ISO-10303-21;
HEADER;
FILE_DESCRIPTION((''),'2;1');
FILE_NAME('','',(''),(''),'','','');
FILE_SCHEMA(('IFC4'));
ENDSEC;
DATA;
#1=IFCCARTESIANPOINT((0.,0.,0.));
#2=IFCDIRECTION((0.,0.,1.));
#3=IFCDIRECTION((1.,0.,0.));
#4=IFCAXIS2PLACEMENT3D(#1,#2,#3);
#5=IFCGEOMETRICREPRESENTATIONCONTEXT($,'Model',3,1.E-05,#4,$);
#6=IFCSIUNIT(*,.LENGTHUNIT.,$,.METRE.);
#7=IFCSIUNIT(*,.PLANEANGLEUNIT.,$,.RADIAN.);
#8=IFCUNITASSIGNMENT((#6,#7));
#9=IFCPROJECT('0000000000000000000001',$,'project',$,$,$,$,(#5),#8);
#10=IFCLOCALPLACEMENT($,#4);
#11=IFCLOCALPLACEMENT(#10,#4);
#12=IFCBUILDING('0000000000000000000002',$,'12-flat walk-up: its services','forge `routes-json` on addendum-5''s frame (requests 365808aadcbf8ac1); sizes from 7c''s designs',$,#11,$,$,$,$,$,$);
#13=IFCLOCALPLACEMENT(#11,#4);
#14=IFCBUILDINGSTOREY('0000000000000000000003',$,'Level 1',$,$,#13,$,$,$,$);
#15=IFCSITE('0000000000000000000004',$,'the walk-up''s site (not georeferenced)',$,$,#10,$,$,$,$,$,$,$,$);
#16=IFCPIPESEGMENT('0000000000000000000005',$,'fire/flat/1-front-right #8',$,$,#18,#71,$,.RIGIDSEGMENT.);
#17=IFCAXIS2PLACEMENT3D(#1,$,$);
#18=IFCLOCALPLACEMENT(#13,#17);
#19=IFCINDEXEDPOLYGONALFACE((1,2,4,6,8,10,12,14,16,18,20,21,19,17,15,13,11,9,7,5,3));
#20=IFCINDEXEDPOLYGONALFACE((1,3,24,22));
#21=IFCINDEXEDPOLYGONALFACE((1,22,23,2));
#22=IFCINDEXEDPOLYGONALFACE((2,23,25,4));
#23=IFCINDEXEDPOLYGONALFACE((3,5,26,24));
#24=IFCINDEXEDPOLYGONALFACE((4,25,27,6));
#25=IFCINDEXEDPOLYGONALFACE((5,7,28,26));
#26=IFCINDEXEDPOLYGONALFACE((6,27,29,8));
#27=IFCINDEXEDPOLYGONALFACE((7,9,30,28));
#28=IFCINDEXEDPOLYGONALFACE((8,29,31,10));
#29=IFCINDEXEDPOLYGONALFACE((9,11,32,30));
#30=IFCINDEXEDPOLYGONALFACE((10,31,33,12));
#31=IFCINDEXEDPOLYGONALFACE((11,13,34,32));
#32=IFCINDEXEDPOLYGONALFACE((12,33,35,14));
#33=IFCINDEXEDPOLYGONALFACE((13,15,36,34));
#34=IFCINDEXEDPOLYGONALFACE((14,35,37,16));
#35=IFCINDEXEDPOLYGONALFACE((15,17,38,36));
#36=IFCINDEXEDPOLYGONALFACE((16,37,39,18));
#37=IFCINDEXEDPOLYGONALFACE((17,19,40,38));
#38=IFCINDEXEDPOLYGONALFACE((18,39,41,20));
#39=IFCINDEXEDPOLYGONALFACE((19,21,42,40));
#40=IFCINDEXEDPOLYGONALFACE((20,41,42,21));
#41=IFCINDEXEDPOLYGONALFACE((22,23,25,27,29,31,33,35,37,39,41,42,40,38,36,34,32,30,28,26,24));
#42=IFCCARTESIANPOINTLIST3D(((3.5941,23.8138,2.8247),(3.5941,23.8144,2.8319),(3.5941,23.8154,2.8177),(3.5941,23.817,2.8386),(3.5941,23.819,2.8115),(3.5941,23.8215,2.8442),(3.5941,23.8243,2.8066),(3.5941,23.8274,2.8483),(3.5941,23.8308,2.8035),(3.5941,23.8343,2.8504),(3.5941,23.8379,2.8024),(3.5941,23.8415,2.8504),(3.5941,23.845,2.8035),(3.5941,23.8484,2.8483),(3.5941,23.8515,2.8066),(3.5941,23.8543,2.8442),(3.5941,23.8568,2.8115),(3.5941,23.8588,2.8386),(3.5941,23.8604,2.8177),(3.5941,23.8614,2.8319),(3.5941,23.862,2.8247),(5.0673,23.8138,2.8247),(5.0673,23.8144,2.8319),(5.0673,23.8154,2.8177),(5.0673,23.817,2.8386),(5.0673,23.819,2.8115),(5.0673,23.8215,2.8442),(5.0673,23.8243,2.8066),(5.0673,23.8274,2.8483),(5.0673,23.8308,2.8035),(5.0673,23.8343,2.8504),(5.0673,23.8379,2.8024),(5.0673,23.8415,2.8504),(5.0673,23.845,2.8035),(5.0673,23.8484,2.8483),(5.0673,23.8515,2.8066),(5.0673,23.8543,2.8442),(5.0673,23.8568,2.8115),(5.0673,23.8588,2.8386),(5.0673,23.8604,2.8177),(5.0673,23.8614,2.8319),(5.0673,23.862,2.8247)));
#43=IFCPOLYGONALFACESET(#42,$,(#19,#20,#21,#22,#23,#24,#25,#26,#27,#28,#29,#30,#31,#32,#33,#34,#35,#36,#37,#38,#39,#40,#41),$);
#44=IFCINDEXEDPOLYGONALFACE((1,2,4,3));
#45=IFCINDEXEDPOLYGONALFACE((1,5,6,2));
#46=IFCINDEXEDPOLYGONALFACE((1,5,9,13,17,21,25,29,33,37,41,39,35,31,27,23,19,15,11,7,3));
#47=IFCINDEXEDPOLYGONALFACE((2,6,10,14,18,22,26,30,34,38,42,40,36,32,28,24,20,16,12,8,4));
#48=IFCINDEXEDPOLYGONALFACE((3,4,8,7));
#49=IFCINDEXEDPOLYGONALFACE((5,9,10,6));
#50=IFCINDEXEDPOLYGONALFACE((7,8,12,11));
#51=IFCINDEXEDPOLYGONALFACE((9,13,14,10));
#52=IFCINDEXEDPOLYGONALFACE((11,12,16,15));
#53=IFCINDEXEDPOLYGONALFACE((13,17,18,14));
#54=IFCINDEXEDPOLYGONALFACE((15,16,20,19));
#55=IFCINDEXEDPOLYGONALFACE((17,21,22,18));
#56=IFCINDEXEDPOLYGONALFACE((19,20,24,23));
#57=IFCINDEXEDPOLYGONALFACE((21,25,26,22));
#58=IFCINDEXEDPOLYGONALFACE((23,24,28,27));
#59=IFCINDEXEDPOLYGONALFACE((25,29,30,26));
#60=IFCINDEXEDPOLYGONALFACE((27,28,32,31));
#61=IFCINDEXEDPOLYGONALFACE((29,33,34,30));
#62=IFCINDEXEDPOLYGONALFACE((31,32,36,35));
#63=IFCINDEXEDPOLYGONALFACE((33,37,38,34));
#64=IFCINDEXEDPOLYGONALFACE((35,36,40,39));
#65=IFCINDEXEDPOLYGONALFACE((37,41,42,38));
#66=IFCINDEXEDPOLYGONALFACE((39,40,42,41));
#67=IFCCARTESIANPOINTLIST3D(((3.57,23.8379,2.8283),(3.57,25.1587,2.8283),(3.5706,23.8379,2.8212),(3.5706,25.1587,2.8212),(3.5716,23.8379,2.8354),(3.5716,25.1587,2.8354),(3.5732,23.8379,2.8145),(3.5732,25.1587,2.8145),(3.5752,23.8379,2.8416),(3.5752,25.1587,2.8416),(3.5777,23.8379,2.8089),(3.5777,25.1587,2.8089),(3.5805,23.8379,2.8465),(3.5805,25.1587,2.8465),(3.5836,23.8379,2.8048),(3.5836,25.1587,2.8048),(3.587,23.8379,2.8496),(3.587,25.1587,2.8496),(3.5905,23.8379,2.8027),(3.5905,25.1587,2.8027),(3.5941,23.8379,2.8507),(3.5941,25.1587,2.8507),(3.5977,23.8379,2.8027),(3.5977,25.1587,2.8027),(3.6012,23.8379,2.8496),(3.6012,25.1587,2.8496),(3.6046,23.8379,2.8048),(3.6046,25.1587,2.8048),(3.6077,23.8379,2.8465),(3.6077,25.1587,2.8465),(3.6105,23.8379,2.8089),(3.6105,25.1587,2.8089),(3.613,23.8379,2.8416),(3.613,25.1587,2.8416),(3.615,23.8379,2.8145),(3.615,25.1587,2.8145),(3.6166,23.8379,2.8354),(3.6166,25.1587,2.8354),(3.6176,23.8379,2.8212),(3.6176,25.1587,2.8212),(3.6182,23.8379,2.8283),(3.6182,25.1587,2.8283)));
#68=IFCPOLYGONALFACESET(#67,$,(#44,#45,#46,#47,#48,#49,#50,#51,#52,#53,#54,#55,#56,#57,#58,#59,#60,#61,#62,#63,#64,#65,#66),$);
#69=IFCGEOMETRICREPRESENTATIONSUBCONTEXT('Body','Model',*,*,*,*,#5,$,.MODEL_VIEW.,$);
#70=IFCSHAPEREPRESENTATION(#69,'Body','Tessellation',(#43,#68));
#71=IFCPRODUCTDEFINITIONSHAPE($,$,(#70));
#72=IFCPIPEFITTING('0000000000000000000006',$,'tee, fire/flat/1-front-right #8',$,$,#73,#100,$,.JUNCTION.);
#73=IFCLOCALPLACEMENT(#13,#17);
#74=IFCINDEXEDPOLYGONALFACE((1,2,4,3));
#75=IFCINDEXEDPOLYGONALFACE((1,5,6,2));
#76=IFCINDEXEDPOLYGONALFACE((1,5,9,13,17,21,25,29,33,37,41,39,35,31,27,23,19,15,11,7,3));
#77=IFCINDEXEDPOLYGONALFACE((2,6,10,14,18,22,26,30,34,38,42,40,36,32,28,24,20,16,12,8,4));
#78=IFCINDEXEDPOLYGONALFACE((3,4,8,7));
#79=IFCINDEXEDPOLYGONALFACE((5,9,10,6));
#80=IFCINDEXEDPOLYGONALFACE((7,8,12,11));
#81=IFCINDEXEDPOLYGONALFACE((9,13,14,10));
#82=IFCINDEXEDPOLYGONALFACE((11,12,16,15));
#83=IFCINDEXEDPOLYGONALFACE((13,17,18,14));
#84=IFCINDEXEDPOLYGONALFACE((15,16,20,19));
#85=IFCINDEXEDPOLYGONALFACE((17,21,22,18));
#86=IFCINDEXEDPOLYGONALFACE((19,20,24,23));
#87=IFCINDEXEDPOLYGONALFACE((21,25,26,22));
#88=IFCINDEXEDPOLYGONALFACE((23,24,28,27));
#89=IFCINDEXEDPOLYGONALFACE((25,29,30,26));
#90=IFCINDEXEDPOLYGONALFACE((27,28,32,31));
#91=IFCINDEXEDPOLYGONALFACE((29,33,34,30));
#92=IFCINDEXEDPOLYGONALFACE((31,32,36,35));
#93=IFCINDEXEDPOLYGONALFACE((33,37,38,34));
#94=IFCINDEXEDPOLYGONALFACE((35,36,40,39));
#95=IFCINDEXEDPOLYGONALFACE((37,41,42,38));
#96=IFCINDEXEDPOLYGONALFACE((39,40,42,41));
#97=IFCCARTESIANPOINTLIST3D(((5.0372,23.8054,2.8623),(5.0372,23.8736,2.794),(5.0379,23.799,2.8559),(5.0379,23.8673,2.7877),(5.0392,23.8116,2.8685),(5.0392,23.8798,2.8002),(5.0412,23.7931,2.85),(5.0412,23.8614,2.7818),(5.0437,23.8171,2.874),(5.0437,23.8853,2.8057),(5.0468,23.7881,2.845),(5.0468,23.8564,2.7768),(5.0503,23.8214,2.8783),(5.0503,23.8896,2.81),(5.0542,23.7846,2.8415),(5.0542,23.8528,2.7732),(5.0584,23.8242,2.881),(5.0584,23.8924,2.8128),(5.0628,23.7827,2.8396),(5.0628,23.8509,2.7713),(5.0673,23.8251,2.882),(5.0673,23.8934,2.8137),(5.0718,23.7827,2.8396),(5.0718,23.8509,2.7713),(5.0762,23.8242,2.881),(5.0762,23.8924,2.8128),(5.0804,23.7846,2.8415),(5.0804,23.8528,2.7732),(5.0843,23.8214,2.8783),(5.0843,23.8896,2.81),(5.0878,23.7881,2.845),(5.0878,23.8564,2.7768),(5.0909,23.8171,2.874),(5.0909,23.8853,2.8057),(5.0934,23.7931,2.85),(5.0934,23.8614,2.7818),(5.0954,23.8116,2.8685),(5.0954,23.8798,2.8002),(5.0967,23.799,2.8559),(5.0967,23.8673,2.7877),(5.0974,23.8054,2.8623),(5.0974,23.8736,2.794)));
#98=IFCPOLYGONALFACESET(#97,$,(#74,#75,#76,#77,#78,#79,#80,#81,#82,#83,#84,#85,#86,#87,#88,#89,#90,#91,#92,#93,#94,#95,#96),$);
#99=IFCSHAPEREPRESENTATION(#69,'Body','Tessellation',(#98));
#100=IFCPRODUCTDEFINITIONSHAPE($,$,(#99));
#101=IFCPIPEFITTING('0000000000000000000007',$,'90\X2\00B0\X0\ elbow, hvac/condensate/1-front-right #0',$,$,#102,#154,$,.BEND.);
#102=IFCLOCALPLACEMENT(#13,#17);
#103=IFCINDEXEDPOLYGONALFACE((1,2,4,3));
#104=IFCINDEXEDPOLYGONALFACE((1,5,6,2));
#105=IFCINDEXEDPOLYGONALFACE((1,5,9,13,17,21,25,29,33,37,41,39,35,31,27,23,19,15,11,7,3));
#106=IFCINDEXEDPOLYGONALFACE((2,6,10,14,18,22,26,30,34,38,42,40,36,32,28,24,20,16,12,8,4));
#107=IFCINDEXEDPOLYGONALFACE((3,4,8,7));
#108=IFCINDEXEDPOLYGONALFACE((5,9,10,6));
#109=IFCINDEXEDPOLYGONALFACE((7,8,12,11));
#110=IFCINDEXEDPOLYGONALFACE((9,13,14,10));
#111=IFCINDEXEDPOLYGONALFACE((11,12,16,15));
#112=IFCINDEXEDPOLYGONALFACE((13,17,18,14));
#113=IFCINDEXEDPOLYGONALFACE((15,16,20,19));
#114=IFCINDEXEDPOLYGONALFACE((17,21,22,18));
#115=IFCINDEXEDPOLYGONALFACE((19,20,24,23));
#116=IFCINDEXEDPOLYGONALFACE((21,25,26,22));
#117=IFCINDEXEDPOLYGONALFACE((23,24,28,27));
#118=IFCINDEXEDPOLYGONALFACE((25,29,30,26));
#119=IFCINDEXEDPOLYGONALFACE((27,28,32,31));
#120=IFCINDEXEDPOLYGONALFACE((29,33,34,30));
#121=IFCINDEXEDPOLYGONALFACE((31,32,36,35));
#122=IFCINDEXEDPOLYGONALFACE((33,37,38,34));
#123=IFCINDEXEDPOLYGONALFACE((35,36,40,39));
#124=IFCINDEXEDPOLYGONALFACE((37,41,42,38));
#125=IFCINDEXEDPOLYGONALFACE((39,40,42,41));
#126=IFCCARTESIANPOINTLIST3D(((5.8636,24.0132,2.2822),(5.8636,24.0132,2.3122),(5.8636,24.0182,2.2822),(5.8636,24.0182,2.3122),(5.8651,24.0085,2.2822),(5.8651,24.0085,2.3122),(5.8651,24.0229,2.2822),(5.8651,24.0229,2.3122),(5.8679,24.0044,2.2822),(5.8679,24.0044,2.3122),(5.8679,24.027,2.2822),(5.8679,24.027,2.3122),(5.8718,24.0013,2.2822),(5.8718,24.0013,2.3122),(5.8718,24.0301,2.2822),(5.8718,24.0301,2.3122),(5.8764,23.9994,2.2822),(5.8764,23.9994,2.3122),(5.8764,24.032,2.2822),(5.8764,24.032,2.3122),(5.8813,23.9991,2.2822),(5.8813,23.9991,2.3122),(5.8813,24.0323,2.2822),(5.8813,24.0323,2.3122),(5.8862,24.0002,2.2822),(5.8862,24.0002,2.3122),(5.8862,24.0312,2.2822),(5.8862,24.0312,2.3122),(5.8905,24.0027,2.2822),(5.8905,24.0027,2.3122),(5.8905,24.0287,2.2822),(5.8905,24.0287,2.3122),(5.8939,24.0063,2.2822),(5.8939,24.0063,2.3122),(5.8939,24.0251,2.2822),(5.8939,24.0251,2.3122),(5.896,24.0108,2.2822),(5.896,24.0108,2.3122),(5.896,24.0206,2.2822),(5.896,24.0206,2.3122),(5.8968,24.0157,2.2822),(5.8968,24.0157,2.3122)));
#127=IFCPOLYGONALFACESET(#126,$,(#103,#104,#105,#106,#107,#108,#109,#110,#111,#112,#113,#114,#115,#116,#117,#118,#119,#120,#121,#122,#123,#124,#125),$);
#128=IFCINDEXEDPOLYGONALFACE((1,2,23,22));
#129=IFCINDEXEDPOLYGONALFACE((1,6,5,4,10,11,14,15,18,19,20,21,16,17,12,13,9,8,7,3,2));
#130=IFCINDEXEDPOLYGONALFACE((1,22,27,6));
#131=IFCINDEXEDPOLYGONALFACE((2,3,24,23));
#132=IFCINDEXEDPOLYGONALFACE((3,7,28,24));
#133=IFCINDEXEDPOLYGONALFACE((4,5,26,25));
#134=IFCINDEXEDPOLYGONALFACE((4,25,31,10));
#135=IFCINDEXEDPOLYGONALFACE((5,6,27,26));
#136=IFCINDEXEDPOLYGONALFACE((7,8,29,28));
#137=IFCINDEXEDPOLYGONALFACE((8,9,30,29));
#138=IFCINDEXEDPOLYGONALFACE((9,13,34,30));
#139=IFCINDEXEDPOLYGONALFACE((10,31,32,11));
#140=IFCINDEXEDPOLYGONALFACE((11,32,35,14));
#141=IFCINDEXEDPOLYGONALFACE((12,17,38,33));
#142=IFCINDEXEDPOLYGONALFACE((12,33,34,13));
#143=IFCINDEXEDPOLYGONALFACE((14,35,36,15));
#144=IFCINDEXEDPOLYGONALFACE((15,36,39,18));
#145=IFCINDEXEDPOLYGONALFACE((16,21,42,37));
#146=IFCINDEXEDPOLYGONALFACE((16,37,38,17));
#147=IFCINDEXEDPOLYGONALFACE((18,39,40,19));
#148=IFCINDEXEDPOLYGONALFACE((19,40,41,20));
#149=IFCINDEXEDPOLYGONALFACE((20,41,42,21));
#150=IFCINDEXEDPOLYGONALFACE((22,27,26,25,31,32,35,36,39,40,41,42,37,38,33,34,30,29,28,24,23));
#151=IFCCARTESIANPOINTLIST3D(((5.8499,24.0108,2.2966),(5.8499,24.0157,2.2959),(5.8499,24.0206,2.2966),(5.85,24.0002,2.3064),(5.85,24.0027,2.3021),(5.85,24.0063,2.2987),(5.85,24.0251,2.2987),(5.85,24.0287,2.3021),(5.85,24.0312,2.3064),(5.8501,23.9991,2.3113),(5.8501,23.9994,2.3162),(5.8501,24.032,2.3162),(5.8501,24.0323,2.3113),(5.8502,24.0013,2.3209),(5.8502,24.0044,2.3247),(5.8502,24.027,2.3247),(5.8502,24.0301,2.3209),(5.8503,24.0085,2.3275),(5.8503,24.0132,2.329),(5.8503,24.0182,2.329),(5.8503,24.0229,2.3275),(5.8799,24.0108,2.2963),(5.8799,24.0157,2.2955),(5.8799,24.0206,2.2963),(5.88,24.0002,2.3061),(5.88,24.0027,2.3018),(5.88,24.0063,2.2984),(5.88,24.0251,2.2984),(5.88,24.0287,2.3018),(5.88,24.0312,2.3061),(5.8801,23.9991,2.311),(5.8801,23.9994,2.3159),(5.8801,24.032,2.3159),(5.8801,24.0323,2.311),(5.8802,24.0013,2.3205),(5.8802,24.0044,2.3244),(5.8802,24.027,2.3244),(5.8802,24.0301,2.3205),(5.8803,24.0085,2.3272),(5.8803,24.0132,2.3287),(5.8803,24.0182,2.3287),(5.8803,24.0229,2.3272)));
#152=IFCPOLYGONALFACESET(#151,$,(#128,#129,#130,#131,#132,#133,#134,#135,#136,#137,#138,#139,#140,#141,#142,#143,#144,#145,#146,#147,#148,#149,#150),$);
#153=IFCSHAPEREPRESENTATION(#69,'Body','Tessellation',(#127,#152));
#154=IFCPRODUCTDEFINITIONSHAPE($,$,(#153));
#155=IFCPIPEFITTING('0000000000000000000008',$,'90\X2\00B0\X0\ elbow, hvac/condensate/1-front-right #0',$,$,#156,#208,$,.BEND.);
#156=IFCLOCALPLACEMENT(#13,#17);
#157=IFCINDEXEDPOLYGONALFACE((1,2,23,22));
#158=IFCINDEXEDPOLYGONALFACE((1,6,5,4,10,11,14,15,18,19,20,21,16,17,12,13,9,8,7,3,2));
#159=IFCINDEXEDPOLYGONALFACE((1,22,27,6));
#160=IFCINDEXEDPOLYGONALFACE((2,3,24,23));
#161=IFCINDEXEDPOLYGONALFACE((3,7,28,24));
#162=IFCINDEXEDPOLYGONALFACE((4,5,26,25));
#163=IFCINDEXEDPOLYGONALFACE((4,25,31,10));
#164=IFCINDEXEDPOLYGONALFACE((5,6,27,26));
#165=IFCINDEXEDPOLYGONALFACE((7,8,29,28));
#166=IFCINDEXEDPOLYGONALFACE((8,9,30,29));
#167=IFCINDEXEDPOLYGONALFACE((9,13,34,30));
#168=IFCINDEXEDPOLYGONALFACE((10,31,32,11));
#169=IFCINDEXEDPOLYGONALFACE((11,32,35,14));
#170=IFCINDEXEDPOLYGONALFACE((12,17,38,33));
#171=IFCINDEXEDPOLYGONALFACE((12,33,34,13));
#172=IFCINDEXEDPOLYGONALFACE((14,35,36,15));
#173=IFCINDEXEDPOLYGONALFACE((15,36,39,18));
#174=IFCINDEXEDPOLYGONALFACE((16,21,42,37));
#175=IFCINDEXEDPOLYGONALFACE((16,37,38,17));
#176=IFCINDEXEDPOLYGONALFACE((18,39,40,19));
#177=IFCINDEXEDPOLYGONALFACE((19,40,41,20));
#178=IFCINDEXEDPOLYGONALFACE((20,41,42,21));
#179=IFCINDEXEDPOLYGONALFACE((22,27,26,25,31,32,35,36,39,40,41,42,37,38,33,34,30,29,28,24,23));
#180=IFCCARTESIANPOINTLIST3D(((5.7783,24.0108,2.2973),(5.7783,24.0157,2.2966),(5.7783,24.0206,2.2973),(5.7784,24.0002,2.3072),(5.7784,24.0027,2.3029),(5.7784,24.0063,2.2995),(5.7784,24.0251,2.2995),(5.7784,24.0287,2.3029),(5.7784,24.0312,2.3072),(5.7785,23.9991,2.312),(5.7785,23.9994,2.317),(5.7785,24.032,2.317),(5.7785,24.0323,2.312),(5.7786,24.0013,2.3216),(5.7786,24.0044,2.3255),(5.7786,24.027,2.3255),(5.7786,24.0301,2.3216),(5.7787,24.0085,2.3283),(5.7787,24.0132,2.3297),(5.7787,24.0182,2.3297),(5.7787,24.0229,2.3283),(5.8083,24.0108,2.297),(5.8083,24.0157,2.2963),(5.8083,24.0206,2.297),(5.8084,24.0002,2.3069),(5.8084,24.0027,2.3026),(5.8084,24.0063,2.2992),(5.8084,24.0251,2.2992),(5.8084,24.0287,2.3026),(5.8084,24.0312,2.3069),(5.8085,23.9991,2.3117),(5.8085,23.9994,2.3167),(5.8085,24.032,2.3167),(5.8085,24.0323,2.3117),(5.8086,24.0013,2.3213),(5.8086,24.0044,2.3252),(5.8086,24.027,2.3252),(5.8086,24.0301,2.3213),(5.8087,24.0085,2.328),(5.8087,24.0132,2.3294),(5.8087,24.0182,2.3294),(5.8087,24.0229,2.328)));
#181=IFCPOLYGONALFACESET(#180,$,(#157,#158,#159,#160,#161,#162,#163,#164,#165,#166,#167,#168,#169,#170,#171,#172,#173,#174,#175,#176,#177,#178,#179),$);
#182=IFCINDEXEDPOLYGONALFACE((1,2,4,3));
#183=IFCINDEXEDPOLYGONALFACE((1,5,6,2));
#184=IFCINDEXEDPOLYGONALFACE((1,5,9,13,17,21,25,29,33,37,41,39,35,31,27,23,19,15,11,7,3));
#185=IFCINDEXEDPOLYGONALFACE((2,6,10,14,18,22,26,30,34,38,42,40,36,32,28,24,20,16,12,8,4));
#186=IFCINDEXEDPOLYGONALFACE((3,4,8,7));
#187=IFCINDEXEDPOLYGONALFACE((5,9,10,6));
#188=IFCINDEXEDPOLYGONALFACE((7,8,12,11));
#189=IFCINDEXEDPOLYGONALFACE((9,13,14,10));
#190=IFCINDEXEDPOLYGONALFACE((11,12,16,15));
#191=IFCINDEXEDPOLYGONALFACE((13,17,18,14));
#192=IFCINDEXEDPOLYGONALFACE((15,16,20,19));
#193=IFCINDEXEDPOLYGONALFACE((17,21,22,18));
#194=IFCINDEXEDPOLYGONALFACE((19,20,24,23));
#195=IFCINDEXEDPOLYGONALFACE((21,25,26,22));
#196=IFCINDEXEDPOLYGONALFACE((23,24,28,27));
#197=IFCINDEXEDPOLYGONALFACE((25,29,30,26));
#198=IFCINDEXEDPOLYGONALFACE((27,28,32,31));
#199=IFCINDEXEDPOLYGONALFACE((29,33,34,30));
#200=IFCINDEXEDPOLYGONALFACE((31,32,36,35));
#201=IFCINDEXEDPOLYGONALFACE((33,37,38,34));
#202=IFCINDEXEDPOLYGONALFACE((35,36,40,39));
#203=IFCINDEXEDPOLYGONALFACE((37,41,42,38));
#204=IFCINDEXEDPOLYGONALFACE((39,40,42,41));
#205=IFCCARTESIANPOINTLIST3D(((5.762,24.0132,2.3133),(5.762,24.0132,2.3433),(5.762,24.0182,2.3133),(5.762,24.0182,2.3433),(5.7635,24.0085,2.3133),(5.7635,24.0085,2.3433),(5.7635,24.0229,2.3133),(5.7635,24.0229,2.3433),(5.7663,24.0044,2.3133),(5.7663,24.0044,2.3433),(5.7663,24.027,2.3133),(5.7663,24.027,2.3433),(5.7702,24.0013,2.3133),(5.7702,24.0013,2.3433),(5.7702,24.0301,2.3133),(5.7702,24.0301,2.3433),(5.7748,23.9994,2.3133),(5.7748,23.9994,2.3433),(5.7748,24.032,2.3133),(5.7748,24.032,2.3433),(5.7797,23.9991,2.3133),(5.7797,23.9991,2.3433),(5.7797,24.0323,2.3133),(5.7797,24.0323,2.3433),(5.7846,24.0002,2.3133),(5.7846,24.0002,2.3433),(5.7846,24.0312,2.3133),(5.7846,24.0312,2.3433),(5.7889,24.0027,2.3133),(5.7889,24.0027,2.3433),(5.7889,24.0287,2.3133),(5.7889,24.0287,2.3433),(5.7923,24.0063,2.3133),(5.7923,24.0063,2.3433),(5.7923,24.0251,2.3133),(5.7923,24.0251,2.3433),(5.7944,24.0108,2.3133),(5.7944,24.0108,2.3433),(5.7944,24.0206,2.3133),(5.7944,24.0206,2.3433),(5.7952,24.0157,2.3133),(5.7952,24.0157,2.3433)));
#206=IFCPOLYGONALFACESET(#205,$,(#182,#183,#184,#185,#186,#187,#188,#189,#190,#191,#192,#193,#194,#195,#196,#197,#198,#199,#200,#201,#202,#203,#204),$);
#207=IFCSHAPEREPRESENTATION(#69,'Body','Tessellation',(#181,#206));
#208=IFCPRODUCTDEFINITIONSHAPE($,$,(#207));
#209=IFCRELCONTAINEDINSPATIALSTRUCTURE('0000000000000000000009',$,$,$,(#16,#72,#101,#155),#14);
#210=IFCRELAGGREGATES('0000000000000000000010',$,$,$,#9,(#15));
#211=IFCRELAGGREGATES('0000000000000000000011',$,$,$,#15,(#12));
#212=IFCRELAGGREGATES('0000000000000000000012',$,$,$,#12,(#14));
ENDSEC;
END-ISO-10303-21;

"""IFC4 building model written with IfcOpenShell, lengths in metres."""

from ifc_helpers import new_model, entity, si_unit, frame, origin_with_axes, place, context, subcontext, project, spatial, element, save


model = new_model("IFC4")

# Units and contexts
model_context = context("Model", 3, precision=1e-05, world=origin_with_axes())
body_context = subcontext(model_context, "Body", "Model", "MODEL_VIEW")
ifc_project = project(units=[si_unit("LENGTHUNIT", "METRE"), si_unit("PLANEANGLEUNIT", "RADIAN")], contexts=[model_context])

# Site, building, storey
site_placement = place(None, origin_with_axes())
site = spatial("IfcSite", under=ifc_project, at=site_placement, Name="the walk-up's site (not georeferenced)")
building_placement = place(site_placement, origin_with_axes())
building = spatial("IfcBuilding", under=site, at=building_placement, Name="12-flat walk-up: its services", Description="forge `routes-json` on addendum-5's frame (requests 365808aadcbf8ac1); sizes from 7c's designs")
storey_placement = place(building_placement, origin_with_axes())
storey = spatial("IfcBuildingStorey", under=building, at=storey_placement, Name="Level 1")

# Pipe segment
pipe_segment_1_placement = place(storey_placement, frame((5.0673, 23.8379, 2.8265), z_axis=(0.0, 0.0, 1.0), x_axis=(1.0, 0.0, 0.0)))
element("IfcPipeSegment", 1, at=pipe_segment_1_placement, inside=storey, Name="fire/flat/1-front-right #8", PredefinedType="RIGIDSEGMENT", context=body_context, shape_type="AdvancedSweptSolid", body=[
    entity("IfcSweptDiskSolid", entity("IfcPolyline", [entity("IfcCartesianPoint", [0.0, 0.0, 0.0]), entity("IfcCartesianPoint", [-1.4732, 0.0, 0.0])]), 0.0241),
    entity("IfcSweptDiskSolid", entity("IfcPolyline", [entity("IfcCartesianPoint", [-1.4732, 0.0, 0.0]), entity("IfcCartesianPoint", [-1.4732, 1.3208, 0.0])]), 0.0241),
])

# Pipe fitting
pipe_fitting_1_placement = place(storey_placement, frame((5.0673, 23.8038, 2.8607), z_axis=(0.0, 0.0, 1.0), x_axis=(1.0, 0.0, 0.0)))
element("IfcPipeFitting", 2, at=pipe_fitting_1_placement, inside=storey, Name="tee, fire/flat/1-front-right #8", PredefinedType="JUNCTION", context=body_context, shape_type="AdvancedSweptSolid", body=[
    entity("IfcSweptDiskSolid", entity("IfcPolyline", [entity("IfcCartesianPoint", [0.0, 0.0, 0.0]), entity("IfcCartesianPoint", [0.0, 0.0682, -0.0682])]), 0.0302),
])

# Pipe fittings
pipe_fitting_2_placement = place(storey_placement, frame((5.8801, 24.0157, 2.2822), z_axis=(0.0, 0.0, 1.0), x_axis=(1.0, 0.0, 0.0)))
element("IfcPipeFitting", 3, at=pipe_fitting_2_placement, inside=storey, Name="90° elbow, hvac/condensate/1-front-right #0", PredefinedType="BEND", context=body_context, shape_type="AdvancedSweptSolid", body=[
    entity("IfcSweptDiskSolid", entity("IfcPolyline", [entity("IfcCartesianPoint", [0.0, 0.0, 0.0]), entity("IfcCartesianPoint", [0.0, 0.0, 0.03])]), 0.0167),
    entity("IfcSweptDiskSolid", entity("IfcPolyline", [entity("IfcCartesianPoint", [0.0, 0.0, 0.03]), entity("IfcCartesianPoint", [-0.03, 0.0, 0.0303])]), 0.0167),
])
pipe_fitting_3_placement = place(storey_placement, frame((5.8085, 24.0157, 2.313), z_axis=(0.0, 0.0, 1.0), x_axis=(1.0, 0.0, 0.0)))
element("IfcPipeFitting", 4, at=pipe_fitting_3_placement, inside=storey, Name="90° elbow, hvac/condensate/1-front-right #0", PredefinedType="BEND", context=body_context, shape_type="AdvancedSweptSolid", body=[
    entity("IfcSweptDiskSolid", entity("IfcPolyline", [entity("IfcCartesianPoint", [0.0, 0.0, 0.0]), entity("IfcCartesianPoint", [-0.03, 0.0, 0.0003])]), 0.0167),
    entity("IfcSweptDiskSolid", entity("IfcPolyline", [entity("IfcCartesianPoint", [-0.03, 0.0, 0.0003]), entity("IfcCartesianPoint", [-0.03, 0.0, 0.0303])]), 0.0167),
])

save(model, "model.ifc")
